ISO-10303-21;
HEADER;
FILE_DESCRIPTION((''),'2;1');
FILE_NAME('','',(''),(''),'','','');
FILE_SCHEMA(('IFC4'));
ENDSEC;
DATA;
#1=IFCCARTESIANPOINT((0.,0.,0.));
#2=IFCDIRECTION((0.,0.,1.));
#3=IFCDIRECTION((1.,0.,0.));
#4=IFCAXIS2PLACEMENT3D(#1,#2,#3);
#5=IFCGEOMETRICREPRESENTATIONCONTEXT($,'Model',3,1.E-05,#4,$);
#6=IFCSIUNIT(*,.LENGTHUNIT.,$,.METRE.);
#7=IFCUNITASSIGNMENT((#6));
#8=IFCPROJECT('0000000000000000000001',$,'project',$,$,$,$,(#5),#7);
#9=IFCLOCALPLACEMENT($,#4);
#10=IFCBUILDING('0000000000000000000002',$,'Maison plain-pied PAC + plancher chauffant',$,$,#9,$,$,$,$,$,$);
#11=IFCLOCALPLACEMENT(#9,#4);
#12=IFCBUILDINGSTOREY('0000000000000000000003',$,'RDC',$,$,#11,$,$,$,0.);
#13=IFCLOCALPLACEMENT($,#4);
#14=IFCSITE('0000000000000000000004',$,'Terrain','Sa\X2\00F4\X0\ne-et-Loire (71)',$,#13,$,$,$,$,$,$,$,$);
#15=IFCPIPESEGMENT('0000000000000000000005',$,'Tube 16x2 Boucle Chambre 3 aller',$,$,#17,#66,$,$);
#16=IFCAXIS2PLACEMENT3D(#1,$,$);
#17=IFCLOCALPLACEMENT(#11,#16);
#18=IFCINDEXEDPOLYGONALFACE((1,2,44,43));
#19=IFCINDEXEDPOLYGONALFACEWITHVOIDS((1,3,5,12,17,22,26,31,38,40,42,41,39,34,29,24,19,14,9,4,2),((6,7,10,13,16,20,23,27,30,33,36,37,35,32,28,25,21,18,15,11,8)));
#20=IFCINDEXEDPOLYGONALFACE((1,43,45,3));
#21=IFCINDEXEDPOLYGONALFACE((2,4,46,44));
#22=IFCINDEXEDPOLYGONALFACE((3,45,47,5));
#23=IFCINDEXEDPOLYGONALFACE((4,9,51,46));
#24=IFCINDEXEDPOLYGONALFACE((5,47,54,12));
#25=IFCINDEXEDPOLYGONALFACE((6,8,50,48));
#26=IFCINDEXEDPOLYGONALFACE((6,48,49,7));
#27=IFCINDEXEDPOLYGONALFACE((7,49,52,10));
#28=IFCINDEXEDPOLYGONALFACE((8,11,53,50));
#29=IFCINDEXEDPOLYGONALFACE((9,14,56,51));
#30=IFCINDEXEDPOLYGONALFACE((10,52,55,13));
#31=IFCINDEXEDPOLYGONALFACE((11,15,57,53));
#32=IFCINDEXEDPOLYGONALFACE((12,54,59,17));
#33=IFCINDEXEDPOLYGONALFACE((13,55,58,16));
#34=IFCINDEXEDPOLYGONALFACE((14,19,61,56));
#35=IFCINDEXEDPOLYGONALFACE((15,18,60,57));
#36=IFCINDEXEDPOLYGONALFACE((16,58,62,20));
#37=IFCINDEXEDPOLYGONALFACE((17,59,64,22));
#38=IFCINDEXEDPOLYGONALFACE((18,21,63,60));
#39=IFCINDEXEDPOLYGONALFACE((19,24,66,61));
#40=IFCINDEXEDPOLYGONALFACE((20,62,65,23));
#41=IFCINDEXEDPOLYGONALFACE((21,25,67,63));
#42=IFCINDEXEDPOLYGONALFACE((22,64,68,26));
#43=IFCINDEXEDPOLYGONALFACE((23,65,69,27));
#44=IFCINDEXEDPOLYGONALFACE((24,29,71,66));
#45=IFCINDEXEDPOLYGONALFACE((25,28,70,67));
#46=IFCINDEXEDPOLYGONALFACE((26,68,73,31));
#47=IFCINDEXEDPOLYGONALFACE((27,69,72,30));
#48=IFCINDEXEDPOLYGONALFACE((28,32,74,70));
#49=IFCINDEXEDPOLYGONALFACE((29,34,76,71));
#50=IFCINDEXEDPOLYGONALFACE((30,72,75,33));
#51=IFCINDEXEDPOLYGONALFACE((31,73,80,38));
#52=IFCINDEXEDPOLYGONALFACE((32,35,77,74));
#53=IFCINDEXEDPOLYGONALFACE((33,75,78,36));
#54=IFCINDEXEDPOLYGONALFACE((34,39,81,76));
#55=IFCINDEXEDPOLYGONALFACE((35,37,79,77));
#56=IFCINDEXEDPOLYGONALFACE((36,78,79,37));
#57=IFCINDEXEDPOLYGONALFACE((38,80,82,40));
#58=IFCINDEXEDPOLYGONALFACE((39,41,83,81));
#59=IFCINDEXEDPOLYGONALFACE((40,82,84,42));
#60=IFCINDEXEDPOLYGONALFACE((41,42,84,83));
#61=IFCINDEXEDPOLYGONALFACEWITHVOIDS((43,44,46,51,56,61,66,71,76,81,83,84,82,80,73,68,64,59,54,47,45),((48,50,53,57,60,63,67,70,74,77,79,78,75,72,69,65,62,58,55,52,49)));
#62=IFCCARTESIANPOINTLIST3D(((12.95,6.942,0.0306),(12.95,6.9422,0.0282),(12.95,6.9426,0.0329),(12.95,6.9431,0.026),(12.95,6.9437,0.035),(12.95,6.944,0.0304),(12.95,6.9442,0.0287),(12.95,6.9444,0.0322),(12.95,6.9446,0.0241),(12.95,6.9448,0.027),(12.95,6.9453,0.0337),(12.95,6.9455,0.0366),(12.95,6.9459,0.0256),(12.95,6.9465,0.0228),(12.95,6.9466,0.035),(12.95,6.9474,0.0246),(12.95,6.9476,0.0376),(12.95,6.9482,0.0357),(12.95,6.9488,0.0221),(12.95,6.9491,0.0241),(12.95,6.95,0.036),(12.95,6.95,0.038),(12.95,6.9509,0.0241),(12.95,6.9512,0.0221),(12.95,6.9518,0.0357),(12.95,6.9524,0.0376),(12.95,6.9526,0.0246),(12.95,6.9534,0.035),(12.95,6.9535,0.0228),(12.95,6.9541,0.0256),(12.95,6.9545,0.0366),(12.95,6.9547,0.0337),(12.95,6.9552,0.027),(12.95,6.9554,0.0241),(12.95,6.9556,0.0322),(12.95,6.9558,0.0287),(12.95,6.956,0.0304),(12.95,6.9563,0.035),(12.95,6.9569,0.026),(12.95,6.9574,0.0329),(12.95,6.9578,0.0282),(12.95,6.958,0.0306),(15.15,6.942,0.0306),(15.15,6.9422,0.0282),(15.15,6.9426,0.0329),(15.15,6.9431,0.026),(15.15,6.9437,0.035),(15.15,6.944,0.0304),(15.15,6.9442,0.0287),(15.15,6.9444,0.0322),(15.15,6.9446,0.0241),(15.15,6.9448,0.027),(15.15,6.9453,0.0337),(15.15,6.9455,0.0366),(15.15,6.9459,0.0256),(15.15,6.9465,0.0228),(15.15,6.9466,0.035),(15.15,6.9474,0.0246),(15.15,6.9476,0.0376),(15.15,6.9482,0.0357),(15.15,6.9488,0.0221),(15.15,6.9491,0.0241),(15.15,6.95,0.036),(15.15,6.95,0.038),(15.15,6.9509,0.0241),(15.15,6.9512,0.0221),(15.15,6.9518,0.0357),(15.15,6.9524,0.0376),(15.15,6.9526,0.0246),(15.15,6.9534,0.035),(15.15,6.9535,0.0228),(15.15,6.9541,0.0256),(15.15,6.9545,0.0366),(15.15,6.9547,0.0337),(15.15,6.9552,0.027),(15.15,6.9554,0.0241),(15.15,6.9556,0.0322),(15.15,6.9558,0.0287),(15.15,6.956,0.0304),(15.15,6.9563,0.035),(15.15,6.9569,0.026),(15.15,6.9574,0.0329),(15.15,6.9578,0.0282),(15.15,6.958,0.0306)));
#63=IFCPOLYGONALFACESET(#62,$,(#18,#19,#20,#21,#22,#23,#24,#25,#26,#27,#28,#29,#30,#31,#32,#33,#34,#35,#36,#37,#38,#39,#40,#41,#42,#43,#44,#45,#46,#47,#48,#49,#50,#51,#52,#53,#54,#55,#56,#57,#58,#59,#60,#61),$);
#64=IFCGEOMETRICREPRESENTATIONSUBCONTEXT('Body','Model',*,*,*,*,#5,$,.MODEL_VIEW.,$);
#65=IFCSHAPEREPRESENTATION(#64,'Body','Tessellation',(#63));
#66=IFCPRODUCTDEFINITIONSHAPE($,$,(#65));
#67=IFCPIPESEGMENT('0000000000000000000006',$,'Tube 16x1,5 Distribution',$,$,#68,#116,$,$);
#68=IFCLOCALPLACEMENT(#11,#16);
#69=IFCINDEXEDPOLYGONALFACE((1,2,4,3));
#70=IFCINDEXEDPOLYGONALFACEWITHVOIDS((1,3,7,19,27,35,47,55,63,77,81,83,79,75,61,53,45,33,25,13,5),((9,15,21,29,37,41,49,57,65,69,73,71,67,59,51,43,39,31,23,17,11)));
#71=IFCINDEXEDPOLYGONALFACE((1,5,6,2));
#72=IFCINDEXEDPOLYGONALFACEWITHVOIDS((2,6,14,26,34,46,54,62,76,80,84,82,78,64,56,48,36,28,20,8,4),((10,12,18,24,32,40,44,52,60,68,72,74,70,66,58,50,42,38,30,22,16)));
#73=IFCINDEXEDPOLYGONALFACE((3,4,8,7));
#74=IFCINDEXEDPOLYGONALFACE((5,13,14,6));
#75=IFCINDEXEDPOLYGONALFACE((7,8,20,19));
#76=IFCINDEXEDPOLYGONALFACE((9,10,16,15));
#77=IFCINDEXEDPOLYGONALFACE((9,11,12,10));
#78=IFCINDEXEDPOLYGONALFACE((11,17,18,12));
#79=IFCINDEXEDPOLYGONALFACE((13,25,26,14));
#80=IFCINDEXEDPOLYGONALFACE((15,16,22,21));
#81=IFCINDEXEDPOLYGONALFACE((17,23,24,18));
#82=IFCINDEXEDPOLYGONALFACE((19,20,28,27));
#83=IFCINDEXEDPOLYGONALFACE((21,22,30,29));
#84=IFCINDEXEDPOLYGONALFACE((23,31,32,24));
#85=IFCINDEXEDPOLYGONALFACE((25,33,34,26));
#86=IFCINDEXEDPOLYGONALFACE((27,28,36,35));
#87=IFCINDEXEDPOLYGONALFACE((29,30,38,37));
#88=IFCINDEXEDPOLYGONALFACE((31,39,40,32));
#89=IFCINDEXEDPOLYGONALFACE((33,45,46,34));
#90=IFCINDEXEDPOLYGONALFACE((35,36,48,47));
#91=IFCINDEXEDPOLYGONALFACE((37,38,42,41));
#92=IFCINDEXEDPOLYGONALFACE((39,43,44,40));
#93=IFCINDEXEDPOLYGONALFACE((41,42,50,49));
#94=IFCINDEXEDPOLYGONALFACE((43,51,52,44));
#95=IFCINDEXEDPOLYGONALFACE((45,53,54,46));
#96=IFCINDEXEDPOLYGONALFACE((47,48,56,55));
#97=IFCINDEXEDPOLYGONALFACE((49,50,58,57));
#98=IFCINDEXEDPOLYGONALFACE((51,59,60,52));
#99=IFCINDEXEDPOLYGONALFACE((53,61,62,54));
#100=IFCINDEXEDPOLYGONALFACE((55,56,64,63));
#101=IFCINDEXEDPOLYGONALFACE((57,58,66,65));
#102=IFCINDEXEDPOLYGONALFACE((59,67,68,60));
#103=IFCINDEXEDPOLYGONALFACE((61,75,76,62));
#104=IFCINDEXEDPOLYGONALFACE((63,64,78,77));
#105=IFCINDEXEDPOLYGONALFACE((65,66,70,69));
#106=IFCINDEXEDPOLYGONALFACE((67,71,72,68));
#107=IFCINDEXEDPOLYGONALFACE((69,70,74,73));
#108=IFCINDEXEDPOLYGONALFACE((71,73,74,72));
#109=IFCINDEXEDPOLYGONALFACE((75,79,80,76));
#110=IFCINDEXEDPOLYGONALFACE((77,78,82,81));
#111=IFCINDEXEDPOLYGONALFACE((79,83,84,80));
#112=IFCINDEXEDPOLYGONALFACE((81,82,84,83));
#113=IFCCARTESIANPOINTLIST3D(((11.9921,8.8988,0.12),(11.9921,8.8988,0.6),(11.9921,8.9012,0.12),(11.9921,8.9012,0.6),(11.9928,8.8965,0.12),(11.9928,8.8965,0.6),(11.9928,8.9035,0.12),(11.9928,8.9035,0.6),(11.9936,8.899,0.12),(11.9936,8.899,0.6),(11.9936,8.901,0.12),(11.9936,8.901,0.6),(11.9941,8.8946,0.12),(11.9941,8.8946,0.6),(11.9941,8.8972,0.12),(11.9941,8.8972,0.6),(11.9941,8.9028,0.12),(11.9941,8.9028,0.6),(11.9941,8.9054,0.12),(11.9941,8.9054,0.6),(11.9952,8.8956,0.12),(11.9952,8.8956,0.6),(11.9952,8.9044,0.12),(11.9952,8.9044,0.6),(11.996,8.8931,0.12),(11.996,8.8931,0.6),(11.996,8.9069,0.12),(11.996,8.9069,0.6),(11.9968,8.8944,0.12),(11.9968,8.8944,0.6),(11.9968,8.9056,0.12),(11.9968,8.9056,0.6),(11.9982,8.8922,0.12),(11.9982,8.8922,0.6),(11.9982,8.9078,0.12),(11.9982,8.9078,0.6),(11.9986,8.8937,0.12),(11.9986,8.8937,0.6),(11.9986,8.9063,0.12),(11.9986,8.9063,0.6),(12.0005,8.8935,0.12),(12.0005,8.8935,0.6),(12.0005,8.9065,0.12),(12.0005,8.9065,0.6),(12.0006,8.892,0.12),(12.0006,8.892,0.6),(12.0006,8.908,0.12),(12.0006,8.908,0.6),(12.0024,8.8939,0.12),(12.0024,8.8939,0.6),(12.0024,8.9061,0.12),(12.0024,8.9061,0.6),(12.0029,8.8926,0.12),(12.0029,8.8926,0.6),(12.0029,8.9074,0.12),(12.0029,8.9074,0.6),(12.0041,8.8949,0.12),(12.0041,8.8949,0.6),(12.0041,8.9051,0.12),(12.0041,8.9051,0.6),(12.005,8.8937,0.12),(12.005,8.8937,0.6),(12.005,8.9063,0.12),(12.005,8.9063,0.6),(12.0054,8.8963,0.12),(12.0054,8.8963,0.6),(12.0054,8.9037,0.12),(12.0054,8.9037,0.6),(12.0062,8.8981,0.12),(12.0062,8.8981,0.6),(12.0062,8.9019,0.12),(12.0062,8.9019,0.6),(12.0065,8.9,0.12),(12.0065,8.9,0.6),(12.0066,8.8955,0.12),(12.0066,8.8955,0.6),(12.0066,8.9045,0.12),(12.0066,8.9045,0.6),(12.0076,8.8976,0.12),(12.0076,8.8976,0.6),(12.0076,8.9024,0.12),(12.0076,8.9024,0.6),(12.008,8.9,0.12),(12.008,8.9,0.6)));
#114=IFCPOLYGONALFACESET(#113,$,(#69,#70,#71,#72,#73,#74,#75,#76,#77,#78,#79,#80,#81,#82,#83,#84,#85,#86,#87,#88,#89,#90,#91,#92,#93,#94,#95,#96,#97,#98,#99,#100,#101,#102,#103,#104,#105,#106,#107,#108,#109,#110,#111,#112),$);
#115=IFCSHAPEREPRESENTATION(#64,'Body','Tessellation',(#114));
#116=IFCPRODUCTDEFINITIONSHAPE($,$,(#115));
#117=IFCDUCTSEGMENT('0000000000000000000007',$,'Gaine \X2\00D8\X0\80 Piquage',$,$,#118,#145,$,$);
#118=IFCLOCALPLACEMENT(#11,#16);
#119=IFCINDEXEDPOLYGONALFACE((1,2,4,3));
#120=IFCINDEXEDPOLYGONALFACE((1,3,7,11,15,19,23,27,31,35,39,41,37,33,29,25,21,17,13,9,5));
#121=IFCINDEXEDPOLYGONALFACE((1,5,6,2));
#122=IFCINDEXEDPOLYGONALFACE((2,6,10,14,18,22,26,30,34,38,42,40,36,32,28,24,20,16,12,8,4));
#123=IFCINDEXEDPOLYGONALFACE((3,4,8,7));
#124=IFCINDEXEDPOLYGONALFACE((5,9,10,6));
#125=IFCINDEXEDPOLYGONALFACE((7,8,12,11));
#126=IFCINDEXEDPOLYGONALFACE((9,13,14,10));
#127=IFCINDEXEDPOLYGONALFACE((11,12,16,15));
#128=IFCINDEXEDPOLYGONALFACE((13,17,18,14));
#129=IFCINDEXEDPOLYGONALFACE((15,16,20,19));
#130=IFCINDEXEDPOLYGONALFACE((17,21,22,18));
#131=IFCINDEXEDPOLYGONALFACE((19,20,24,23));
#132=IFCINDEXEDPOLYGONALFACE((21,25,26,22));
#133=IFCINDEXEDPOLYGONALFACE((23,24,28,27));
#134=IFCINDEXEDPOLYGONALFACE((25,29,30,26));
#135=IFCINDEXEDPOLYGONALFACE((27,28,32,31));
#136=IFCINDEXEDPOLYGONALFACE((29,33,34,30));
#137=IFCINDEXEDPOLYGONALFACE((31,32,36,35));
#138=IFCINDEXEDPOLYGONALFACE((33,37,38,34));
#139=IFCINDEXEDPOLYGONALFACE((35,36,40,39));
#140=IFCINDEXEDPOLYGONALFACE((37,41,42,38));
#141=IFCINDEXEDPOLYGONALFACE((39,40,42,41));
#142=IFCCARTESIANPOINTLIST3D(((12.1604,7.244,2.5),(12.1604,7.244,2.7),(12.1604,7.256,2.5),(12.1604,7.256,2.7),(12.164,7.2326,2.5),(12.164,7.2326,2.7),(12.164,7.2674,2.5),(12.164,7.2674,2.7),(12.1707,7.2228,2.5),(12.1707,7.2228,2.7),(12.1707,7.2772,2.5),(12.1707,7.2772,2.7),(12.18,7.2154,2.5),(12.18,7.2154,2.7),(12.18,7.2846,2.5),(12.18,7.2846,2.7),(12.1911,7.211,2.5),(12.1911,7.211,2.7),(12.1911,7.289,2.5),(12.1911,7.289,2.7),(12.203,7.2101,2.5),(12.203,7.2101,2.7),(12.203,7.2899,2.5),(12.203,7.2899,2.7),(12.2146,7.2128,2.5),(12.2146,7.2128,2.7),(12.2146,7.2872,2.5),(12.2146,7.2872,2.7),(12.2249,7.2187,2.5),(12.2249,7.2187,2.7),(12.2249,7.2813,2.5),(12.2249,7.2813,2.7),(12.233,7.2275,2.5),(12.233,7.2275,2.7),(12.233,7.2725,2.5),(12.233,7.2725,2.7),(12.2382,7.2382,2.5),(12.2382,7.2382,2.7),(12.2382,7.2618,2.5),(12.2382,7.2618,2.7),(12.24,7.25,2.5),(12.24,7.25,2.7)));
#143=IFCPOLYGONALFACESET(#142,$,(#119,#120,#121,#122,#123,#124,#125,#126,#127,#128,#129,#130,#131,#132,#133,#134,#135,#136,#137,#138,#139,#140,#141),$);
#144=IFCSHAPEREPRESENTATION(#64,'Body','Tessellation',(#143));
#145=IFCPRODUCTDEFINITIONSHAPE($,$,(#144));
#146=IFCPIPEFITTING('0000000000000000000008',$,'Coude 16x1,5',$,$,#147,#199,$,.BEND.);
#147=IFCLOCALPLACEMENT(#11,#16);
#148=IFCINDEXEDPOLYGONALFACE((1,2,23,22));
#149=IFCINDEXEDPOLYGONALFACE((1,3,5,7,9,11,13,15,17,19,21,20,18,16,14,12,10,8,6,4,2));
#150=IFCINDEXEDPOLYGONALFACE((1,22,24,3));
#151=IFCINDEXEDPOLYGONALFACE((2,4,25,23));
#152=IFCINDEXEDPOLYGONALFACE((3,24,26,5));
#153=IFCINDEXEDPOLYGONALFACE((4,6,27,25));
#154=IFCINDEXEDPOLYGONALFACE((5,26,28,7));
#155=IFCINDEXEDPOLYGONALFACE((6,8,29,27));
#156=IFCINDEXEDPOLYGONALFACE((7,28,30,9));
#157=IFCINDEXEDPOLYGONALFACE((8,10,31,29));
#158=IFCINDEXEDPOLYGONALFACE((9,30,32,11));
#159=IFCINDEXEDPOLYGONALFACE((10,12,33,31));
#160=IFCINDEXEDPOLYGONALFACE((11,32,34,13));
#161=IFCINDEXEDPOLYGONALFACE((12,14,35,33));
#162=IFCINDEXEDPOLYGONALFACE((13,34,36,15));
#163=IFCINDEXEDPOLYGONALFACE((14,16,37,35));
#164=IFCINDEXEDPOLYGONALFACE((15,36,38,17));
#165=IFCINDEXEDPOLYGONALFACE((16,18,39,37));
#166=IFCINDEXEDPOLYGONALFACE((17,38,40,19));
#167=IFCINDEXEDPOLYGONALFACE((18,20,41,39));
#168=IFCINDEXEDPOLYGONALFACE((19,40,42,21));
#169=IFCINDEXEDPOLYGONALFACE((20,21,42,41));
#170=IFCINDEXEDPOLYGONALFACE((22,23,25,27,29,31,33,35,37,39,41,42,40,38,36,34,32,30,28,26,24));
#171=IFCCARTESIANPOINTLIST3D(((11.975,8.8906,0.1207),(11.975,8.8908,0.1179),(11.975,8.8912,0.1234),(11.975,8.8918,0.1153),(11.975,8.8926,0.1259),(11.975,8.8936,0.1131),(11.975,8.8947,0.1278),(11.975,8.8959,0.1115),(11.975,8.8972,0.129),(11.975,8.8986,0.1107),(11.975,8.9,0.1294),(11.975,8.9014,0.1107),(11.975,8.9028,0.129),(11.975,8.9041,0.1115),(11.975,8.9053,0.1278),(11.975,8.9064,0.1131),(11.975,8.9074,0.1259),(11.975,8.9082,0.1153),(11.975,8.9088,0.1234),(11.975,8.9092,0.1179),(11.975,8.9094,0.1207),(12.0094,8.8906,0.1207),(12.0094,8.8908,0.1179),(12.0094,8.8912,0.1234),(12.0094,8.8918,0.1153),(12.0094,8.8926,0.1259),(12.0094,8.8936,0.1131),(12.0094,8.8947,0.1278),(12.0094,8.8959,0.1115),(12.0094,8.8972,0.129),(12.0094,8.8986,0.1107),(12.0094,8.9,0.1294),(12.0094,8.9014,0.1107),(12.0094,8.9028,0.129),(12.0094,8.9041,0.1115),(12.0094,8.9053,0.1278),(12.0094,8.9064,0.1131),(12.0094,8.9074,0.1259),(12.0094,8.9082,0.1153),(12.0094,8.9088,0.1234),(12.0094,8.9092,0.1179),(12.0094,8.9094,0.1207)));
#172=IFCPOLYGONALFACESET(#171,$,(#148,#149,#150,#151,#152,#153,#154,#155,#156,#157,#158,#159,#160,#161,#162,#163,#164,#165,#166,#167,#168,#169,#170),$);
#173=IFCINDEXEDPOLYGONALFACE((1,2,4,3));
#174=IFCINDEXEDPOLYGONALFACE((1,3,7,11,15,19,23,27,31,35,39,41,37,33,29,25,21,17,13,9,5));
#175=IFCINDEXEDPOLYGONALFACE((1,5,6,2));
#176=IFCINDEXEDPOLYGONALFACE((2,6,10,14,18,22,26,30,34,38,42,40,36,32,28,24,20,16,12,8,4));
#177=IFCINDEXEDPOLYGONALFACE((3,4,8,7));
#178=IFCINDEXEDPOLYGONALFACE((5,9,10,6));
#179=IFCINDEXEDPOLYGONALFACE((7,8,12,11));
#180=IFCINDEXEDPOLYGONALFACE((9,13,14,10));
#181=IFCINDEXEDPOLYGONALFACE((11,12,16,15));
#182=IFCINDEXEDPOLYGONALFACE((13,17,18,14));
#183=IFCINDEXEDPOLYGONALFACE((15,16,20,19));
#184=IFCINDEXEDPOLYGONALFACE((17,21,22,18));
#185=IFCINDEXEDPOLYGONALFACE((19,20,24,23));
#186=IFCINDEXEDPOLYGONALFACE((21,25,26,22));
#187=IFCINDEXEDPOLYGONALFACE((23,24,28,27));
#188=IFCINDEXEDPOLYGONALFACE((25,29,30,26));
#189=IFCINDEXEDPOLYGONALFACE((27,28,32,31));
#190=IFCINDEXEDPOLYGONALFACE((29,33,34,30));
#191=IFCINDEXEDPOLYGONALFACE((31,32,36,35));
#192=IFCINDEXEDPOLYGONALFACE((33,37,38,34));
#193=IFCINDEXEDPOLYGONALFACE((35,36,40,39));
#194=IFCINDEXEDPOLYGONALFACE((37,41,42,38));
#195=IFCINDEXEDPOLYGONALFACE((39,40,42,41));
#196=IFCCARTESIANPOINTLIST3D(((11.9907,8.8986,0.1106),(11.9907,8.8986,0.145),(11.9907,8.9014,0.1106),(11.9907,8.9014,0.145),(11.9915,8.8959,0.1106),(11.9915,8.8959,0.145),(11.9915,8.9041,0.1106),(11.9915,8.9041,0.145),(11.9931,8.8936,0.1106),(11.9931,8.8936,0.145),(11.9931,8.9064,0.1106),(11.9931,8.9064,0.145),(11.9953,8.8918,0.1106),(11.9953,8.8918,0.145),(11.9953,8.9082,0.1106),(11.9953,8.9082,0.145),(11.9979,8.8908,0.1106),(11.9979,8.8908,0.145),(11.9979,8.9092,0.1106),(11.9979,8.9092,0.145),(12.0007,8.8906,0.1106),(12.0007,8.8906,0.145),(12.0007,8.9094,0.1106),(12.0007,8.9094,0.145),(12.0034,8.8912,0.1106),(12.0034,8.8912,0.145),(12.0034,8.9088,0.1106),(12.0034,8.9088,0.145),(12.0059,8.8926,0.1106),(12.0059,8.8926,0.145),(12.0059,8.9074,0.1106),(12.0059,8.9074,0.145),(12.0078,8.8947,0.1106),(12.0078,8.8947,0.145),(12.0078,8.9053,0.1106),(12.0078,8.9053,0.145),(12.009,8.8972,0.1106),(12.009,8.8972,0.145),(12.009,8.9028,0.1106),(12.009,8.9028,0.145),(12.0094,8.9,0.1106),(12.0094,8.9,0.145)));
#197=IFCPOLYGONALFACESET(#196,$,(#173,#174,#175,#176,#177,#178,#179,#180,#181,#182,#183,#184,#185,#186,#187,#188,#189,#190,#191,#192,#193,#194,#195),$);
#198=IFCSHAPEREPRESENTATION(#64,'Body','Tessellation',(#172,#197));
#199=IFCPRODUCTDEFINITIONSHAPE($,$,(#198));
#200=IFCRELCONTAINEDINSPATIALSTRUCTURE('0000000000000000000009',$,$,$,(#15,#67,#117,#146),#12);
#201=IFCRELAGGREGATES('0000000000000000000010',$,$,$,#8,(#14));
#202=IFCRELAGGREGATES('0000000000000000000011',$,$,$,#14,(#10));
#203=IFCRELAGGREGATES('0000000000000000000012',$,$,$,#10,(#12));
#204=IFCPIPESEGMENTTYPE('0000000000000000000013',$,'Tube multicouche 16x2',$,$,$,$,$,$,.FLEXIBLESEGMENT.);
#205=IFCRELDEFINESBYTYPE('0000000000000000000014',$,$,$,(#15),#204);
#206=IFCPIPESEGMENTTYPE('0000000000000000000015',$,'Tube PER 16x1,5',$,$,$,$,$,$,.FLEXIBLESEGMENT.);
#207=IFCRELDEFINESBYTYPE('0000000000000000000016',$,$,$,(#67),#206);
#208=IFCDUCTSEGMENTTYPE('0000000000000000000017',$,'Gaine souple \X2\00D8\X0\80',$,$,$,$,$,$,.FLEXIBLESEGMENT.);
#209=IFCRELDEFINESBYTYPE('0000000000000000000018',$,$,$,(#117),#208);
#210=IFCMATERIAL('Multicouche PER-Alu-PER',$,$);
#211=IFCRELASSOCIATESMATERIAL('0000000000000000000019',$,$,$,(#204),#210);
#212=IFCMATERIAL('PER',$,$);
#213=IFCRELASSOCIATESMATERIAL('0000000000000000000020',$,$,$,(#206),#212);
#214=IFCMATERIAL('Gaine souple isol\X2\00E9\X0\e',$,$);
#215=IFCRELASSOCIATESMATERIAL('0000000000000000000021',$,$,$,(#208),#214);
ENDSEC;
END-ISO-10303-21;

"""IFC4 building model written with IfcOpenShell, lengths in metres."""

from ifc_helpers import new_model, si_unit, frame, origin_with_axes, place, context, subcontext, project, spatial, circle, hollow_circle, extrude, material, type_object, element, save


model = new_model("IFC4")

# Units and contexts
model_context = context("Model", 3, precision=1e-05, world=origin_with_axes())
body_context = subcontext(model_context, "Body", "Model", "MODEL_VIEW")
ifc_project = project(units=[si_unit("LENGTHUNIT", "METRE")], contexts=[model_context])

# Site, building, storey
site_placement = place(None, origin_with_axes())
site = spatial("IfcSite", under=ifc_project, at=site_placement, Name="Terrain", Description="Saône-et-Loire (71)")
building_placement = place(None, origin_with_axes())
building = spatial("IfcBuilding", under=site, at=building_placement, Name="Maison plain-pied PAC + plancher chauffant")
storey_placement = place(building_placement, origin_with_axes())
storey = spatial("IfcBuildingStorey", under=building, at=storey_placement, Name="RDC", Elevation=0.0)

# Pipe segments
ifc_material_1 = material(Name="Multicouche PER-Alu-PER")
pipe_segment_type_1 = type_object("IfcPipeSegmentType", Name="Tube multicouche 16x2", PredefinedType="FLEXIBLESEGMENT", material=ifc_material_1)
pipe_segment_1_placement = place(storey_placement, frame((12.95, 6.95, 0.03), z_axis=(1.0, 0.0, 0.0), x_axis=(0.0, 0.0, 1.0)))
element("IfcPipeSegment", 1, at=pipe_segment_1_placement, inside=storey, type_object=pipe_segment_type_1, Name="Tube 16x2 Boucle Chambre 3 aller", context=body_context, shape_type="SweptSolid", body=[
    extrude(hollow_circle(Radius=0.008, WallThickness=0.002), origin_with_axes(), (0.0, 0.0, 1.0), 2.2),
])
ifc_material_2 = material(Name="PER")
pipe_segment_type_2 = type_object("IfcPipeSegmentType", Name="Tube PER 16x1,5", PredefinedType="FLEXIBLESEGMENT", material=ifc_material_2)
pipe_segment_2_placement = place(storey_placement, frame((12.0, 8.9, 0.12), z_axis=(0.0, 0.0, 1.0), x_axis=(1.0, 0.0, 0.0)))
element("IfcPipeSegment", 2, at=pipe_segment_2_placement, inside=storey, type_object=pipe_segment_type_2, Name="Tube 16x1,5 Distribution", context=body_context, shape_type="SweptSolid", body=[
    extrude(hollow_circle(Radius=0.008, WallThickness=0.0015), origin_with_axes(), (0.0, 0.0, 1.0), 0.48),
])

# Duct segment
ifc_material_3 = material(Name="Gaine souple isolée")
duct_segment_type = type_object("IfcDuctSegmentType", Name="Gaine souple Ø80", PredefinedType="FLEXIBLESEGMENT", material=ifc_material_3)
duct_segment_placement = place(storey_placement, frame((12.2, 7.25, 2.5), z_axis=(0.0, 0.0, 1.0), x_axis=(1.0, 0.0, 0.0)))
element("IfcDuctSegment", 3, at=duct_segment_placement, inside=storey, type_object=duct_segment_type, Name="Gaine Ø80 Piquage", context=body_context, shape_type="SweptSolid", body=[
    extrude(circle(Radius=0.04), origin_with_axes(), (0.0, 0.0, 1.0), 0.2),
])

# Pipe fitting
pipe_fitting_placement = place(storey_placement, frame((12.0, 8.9, 0.12), z_axis=(0.0, 0.0, 1.0), x_axis=(1.0, 0.0, 0.0)))
element("IfcPipeFitting", 4, at=pipe_fitting_placement, inside=storey, Name="Coude 16x1,5", PredefinedType="BEND", context=body_context, shape_type="SweptSolid", body=[
    extrude(circle(Radius=0.0094), frame((0.0094, 0.0, 0.0), z_axis=(-1.0, 0.0, 0.0), x_axis=(0.0, 0.0, 1.0)), (0.0, 0.0, 1.0), 0.0344),
    extrude(circle(Radius=0.0094), frame((0.0, 0.0, -0.0094), z_axis=(0.0, 0.0, 1.0), x_axis=(1.0, 0.0, 0.0)), (0.0, 0.0, 1.0), 0.0344),
])

save(model, "model.ifc")
